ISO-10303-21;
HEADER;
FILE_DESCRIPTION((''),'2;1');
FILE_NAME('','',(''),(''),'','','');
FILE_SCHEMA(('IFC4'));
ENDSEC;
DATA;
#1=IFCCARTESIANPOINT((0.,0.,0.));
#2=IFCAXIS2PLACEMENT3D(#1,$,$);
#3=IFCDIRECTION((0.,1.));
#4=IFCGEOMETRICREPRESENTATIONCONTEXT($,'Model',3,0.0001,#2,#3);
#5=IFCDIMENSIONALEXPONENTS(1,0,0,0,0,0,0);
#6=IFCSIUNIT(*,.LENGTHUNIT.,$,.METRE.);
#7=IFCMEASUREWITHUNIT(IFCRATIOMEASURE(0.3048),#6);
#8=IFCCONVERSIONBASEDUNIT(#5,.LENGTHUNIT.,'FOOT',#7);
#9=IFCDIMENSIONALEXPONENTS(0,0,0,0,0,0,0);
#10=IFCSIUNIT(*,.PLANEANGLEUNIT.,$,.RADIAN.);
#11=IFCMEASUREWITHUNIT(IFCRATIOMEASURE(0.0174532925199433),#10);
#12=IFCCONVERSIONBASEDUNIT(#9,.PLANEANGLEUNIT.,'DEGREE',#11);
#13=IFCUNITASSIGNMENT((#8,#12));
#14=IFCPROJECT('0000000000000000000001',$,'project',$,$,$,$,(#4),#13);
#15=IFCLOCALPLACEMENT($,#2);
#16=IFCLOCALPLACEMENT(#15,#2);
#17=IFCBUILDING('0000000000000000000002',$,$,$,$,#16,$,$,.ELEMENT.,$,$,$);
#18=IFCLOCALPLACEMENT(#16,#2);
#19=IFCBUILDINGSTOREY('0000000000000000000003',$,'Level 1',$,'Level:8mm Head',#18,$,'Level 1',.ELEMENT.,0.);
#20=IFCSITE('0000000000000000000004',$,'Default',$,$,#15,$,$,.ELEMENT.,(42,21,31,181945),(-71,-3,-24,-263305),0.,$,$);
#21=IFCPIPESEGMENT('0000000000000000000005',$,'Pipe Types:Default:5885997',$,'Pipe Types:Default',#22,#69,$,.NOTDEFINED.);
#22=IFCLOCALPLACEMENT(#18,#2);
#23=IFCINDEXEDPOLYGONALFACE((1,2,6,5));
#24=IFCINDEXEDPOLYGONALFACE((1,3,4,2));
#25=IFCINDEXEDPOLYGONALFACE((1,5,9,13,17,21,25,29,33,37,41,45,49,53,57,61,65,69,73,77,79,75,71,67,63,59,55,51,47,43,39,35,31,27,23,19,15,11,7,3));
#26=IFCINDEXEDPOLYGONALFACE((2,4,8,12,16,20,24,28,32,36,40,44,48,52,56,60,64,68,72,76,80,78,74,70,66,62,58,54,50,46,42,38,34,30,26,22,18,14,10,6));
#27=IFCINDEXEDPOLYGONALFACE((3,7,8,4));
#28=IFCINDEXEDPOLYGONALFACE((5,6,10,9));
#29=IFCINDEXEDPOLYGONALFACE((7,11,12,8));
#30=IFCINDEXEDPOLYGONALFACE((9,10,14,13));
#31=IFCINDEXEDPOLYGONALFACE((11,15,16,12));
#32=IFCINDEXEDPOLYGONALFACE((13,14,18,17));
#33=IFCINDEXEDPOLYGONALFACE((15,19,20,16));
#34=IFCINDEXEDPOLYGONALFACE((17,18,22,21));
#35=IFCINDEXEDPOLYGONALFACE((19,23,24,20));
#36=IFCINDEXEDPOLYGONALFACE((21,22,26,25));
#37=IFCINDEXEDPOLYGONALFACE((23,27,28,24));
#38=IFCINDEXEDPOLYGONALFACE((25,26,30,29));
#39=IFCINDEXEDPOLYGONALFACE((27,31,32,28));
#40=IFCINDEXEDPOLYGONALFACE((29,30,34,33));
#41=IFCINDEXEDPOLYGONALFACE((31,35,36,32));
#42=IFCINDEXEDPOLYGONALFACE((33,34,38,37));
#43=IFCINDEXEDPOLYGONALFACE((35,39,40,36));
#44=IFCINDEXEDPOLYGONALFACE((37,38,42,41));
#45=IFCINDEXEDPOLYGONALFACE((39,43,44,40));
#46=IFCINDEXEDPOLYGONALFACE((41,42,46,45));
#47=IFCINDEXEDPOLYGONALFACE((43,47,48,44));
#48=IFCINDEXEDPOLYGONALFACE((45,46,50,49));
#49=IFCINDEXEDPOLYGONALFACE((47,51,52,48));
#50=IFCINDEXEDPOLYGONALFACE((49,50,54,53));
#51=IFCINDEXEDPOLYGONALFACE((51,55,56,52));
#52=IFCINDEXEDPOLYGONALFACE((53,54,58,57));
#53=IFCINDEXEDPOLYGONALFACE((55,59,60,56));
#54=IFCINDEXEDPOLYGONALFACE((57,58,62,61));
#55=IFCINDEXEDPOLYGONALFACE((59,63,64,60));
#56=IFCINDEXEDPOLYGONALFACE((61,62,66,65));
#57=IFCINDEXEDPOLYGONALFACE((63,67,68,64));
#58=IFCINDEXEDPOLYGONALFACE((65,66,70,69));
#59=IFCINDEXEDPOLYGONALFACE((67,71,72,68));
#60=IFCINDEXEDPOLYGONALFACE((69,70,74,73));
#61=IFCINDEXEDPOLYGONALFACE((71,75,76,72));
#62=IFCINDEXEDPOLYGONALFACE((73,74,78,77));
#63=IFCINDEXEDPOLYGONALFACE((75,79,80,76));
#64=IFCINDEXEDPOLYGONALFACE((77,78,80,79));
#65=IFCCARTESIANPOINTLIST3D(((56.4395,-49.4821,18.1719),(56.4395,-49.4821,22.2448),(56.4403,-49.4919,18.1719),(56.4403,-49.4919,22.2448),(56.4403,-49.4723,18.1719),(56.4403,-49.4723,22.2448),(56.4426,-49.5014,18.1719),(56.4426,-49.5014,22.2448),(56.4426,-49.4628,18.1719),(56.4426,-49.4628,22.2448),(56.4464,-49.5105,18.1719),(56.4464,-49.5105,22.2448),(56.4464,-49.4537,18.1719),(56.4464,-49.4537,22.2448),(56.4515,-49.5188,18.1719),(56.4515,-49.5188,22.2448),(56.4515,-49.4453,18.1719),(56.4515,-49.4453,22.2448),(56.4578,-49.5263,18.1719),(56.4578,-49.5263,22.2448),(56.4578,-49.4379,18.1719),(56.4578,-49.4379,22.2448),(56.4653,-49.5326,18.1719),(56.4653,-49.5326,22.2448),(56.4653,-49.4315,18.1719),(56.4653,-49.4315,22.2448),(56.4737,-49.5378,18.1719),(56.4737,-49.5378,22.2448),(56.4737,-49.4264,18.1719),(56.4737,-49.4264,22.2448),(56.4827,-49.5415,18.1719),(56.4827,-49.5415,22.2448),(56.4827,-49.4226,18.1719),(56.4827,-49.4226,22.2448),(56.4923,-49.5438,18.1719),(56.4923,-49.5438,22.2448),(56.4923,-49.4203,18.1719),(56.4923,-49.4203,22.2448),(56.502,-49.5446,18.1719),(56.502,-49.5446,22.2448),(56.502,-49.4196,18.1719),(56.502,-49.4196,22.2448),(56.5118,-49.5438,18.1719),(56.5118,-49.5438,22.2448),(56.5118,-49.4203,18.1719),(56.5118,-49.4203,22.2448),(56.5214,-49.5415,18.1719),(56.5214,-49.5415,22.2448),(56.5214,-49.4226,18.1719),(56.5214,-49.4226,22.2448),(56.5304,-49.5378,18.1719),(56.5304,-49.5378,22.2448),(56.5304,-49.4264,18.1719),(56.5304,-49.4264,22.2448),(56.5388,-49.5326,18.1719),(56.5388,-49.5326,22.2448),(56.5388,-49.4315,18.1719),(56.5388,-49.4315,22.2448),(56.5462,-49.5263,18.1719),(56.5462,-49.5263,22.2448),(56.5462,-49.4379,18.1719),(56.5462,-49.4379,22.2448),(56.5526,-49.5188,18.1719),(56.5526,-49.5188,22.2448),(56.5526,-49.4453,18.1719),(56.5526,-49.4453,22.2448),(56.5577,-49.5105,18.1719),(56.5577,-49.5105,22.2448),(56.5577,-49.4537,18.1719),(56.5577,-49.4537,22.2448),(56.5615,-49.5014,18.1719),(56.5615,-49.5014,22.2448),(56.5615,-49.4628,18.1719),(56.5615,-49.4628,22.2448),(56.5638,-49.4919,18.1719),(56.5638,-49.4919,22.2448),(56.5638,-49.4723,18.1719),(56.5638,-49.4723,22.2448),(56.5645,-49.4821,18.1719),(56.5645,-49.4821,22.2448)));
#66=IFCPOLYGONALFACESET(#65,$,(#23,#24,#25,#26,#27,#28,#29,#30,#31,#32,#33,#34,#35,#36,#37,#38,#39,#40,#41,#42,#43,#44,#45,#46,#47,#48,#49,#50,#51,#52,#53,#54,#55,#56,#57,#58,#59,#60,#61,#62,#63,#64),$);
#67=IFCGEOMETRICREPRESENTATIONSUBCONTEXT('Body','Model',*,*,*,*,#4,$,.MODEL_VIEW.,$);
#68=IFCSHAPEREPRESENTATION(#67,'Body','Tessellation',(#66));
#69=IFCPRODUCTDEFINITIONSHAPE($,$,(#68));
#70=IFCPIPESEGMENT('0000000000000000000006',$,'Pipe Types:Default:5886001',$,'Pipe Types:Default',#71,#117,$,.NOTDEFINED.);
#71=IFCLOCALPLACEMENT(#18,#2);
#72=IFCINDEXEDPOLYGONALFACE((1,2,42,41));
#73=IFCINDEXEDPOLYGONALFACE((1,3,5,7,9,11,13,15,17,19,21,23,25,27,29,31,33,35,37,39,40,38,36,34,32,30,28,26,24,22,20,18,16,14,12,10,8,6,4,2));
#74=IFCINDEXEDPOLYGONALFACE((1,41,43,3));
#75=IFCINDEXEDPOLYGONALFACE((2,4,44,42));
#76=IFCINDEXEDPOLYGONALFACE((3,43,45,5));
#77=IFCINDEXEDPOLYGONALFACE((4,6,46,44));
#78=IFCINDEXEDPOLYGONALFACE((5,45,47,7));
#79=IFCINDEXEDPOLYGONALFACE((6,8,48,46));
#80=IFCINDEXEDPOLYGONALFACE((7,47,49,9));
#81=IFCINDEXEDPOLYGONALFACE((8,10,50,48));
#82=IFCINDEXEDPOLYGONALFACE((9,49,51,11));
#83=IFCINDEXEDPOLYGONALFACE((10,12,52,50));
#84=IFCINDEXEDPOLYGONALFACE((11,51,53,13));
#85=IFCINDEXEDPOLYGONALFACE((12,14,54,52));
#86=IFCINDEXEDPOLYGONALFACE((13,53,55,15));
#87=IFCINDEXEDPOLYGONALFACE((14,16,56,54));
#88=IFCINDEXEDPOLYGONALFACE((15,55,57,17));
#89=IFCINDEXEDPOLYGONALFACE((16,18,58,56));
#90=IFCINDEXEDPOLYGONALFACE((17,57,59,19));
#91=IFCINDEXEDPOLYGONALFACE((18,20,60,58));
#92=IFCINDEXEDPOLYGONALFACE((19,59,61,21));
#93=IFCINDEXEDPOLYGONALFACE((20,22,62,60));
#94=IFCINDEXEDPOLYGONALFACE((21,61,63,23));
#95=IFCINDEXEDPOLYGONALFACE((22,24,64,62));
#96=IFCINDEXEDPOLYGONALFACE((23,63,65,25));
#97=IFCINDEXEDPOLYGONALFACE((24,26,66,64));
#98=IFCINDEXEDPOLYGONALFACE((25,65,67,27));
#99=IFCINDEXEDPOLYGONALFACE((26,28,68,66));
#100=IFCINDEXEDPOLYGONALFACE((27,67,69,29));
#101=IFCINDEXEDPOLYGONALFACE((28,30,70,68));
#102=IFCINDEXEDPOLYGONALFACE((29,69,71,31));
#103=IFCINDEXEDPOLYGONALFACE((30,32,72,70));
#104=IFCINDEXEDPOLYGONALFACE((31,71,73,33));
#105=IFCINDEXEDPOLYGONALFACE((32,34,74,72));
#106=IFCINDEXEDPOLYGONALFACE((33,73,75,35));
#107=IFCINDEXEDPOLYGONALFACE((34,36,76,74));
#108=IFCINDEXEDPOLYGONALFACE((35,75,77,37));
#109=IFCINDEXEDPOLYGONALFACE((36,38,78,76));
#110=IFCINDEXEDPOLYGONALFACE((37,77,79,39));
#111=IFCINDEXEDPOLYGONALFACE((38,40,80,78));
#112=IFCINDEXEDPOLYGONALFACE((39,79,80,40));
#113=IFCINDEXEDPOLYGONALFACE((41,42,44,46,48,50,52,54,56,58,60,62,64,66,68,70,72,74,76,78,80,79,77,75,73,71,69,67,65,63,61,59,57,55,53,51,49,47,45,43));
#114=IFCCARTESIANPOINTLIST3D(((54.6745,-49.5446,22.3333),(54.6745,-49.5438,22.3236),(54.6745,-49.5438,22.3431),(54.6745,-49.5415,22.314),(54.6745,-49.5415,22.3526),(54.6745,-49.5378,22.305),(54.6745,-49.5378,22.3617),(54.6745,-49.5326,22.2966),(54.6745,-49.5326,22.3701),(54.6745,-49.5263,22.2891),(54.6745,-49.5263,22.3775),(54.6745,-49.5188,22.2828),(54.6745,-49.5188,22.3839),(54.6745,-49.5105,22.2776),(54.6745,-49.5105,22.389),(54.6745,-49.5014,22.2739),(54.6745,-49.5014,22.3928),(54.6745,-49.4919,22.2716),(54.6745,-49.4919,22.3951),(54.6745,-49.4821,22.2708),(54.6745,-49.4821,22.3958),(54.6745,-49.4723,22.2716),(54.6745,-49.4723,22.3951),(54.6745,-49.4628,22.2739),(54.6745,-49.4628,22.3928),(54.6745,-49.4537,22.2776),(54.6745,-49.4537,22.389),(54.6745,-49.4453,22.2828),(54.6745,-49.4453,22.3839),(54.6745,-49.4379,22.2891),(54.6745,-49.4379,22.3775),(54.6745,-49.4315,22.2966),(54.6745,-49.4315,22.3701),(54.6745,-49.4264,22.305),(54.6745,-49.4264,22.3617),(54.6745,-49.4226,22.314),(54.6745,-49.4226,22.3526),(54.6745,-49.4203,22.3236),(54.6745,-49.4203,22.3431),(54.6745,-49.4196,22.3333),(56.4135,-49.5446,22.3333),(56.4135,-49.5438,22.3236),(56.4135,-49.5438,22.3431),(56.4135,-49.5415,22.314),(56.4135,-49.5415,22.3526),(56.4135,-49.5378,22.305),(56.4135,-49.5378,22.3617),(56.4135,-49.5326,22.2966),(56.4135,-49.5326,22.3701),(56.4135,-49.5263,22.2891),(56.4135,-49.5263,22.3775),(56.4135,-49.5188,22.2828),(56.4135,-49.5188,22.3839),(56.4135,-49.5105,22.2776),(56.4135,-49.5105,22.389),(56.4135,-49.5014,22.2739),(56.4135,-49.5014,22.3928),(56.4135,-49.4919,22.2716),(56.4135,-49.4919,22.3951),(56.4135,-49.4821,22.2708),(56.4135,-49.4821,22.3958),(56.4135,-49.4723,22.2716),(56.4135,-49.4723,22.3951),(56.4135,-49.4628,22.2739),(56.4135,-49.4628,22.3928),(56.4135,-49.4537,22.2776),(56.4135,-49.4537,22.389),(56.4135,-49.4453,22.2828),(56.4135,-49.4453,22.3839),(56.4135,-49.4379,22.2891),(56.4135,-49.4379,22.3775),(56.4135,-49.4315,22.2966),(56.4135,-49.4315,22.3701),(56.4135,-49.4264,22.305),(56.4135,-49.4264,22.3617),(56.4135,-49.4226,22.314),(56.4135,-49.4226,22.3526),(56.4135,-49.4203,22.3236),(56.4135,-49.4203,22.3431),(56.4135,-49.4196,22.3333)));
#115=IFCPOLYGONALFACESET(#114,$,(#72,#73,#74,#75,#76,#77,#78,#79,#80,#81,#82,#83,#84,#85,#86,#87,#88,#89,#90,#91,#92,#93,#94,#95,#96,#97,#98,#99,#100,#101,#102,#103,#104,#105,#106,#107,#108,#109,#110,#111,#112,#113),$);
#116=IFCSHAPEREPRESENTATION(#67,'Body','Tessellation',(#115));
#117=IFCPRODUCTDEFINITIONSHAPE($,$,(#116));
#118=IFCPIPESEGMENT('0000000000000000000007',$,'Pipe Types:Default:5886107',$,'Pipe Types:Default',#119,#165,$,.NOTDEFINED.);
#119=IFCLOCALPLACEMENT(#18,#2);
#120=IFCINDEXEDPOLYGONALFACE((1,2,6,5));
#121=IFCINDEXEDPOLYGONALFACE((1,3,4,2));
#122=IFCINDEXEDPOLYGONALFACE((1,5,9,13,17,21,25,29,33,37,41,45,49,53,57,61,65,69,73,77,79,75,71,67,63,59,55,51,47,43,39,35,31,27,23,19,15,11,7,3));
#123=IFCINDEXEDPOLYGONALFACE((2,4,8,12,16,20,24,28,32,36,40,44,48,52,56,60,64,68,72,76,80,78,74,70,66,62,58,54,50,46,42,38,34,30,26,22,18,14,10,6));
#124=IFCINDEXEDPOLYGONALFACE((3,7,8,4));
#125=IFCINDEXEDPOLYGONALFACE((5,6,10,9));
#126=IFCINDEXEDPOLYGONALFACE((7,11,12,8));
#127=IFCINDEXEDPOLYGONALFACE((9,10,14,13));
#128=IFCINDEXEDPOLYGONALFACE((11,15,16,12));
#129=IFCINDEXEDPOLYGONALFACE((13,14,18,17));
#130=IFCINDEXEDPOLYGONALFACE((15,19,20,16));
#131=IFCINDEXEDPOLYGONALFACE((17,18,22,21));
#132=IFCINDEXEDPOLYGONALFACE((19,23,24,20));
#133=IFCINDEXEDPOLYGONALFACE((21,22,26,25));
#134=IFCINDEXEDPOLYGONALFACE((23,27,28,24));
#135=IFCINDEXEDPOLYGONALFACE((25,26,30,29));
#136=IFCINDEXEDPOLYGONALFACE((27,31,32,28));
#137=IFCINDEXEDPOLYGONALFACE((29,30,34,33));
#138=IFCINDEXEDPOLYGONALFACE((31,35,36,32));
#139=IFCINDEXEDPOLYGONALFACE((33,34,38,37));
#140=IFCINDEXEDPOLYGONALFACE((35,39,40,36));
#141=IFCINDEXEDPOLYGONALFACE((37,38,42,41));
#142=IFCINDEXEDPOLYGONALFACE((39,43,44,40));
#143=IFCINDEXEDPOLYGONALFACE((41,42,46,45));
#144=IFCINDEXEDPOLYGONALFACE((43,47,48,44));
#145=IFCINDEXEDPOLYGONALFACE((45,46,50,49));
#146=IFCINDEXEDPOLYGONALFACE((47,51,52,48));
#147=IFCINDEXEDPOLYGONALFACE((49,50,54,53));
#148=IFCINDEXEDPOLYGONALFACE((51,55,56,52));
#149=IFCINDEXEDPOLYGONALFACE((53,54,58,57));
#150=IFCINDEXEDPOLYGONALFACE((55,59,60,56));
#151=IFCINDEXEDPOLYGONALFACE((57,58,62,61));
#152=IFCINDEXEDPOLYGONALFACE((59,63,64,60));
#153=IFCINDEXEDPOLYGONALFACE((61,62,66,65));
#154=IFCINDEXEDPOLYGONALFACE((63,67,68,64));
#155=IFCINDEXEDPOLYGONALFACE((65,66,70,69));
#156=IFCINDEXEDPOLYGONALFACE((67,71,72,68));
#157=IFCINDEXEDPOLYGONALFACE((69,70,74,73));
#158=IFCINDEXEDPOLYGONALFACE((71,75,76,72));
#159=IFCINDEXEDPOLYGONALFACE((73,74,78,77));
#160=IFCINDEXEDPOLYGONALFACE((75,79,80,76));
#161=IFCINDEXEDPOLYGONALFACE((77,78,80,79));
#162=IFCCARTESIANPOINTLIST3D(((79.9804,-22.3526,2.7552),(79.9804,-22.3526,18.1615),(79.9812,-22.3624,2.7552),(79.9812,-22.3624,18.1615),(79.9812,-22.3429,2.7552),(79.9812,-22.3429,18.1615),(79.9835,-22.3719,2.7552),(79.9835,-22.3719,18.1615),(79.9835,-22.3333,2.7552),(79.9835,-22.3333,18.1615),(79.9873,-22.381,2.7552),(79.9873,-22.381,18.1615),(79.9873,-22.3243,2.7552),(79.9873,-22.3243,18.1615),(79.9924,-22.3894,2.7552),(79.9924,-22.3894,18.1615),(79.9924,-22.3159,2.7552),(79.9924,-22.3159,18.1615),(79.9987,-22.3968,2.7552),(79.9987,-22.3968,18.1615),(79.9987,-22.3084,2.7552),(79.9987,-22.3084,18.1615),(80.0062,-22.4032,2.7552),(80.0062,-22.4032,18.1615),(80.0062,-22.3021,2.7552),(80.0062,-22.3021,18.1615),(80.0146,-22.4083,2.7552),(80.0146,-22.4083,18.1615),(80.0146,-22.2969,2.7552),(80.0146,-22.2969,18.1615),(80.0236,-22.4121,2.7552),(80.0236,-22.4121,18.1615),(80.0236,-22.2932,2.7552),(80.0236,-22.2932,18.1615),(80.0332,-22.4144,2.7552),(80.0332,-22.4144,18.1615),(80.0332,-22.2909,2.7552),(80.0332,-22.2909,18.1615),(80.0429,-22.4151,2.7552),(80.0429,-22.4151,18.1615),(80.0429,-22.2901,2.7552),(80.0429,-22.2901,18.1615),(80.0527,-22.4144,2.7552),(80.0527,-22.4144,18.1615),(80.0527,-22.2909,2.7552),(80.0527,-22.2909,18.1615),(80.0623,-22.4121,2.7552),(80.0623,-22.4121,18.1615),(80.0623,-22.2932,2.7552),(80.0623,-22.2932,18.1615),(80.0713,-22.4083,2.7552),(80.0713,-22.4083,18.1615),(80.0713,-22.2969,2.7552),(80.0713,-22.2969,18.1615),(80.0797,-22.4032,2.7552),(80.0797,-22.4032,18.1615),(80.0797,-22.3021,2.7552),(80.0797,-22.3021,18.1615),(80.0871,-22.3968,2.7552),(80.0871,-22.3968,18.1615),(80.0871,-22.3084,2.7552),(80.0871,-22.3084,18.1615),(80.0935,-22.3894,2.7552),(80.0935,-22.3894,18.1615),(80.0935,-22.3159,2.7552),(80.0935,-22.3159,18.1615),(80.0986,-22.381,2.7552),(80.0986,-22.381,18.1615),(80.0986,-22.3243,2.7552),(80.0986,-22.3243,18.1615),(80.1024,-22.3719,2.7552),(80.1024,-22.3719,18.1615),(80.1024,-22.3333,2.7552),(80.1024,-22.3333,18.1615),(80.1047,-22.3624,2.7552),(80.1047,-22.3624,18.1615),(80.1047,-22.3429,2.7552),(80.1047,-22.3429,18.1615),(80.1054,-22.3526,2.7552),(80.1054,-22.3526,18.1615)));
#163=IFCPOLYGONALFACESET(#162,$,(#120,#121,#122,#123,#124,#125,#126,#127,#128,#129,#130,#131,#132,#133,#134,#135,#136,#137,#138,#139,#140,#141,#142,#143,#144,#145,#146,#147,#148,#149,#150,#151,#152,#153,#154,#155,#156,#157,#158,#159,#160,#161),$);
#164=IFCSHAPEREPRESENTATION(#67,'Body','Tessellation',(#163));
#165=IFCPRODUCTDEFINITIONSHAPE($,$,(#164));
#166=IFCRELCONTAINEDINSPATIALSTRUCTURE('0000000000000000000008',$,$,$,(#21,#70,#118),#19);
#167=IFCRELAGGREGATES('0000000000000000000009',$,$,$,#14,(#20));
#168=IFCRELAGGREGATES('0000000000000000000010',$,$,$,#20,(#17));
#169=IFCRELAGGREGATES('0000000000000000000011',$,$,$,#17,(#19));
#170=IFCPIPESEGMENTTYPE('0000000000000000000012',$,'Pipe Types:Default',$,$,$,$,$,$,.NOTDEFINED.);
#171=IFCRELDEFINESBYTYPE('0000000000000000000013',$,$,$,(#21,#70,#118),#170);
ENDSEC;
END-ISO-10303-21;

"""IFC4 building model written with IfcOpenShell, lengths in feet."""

from ifc_helpers import new_model, entity, si_unit, converted_unit, direction, frame, origin, place, context, subcontext, project, spatial, indexed_curve, outline, extrude, type_object, element, save


model = new_model("IFC4")

# Units and contexts
model_context = context("Model", 3, precision=0.0001, world=origin(), true_north=direction((0.0, 1.0)))
body_context = subcontext(model_context, "Body", "Model", "MODEL_VIEW")
ifc_project = project(units=[converted_unit("LENGTHUNIT", "FOOT", entity("IfcRatioMeasure", 0.3048), si_unit("LENGTHUNIT", "METRE"), dimensions=[1, 0, 0, 0, 0, 0, 0]), converted_unit("PLANEANGLEUNIT", "DEGREE", entity("IfcRatioMeasure", 0.0174532925199433), si_unit("PLANEANGLEUNIT", "RADIAN"), dimensions=[0, 0, 0, 0, 0, 0, 0])], contexts=[model_context])

# Site, building, storey
site_placement = place(None, origin())
site = spatial("IfcSite", under=ifc_project, at=site_placement, Name="Default", CompositionType="ELEMENT", RefLatitude=(42, 21, 31, 181945), RefLongitude=(-71, -3, -24, -263305), RefElevation=0.0)
building_placement = place(site_placement, origin())
building = spatial("IfcBuilding", under=site, at=building_placement, CompositionType="ELEMENT")
storey_placement = place(building_placement, origin())
storey = spatial("IfcBuildingStorey", under=building, at=storey_placement, Name="Level 1", ObjectType="Level:8mm Head", LongName="Level 1", CompositionType="ELEMENT", Elevation=0.0)

# Pipe segments
pipe_segment_type = type_object("IfcPipeSegmentType", Name="Pipe Types:Default", PredefinedType="NOTDEFINED")
pipe_segment_1_placement = place(storey_placement, origin())
element("IfcPipeSegment", 1, at=pipe_segment_1_placement, inside=storey, type_object=pipe_segment_type, Name="Pipe Types:Default:5885997", ObjectType="Pipe Types:Default", PredefinedType="NOTDEFINED", context=body_context, shape_type="SweptSolid", body=[
    extrude(outline(indexed_curve([(0.0625, 0.0), (0.0617, 0.0098), (0.0594, 0.0193), (0.0557, 0.0284), (0.0506, 0.0367), (0.0442, 0.0442), (0.0367, 0.0506), (0.0284, 0.0557), (0.0193, 0.0594), (0.0098, 0.0617), (0.0, 0.0625), (-0.0098, 0.0617), (-0.0193, 0.0594), (-0.0284, 0.0557), (-0.0367, 0.0506), (-0.0442, 0.0442), (-0.0506, 0.0367), (-0.0557, 0.0284), (-0.0594, 0.0193), (-0.0617, 0.0098), (-0.0625, 0.0), (-0.0617, -0.0098), (-0.0594, -0.0193), (-0.0557, -0.0284), (-0.0506, -0.0367), (-0.0442, -0.0442), (-0.0367, -0.0506), (-0.0284, -0.0557), (-0.0193, -0.0594), (-0.0098, -0.0617), (0.0, -0.0625), (0.0098, -0.0617), (0.0193, -0.0594), (0.0284, -0.0557), (0.0367, -0.0506), (0.0442, -0.0442), (0.0506, -0.0367), (0.0557, -0.0284), (0.0594, -0.0193), (0.0617, -0.0098), (0.0625, 0.0)], self_intersect=False)), frame((56.502, -49.4821, 18.1719), z_axis=(0.0, 0.0, 1.0), x_axis=(-1.0, 0.0, 0.0)), (0.0, 0.0, 1.0), 4.0729),
])
pipe_segment_2_placement = place(storey_placement, origin())
element("IfcPipeSegment", 2, at=pipe_segment_2_placement, inside=storey, type_object=pipe_segment_type, Name="Pipe Types:Default:5886001", ObjectType="Pipe Types:Default", PredefinedType="NOTDEFINED", context=body_context, shape_type="SweptSolid", body=[
    extrude(outline(indexed_curve([(0.0625, 0.0), (0.0617, 0.0098), (0.0594, 0.0193), (0.0557, 0.0284), (0.0506, 0.0367), (0.0442, 0.0442), (0.0367, 0.0506), (0.0284, 0.0557), (0.0193, 0.0594), (0.0098, 0.0617), (0.0, 0.0625), (-0.0098, 0.0617), (-0.0193, 0.0594), (-0.0284, 0.0557), (-0.0367, 0.0506), (-0.0442, 0.0442), (-0.0506, 0.0367), (-0.0557, 0.0284), (-0.0594, 0.0193), (-0.0617, 0.0098), (-0.0625, 0.0), (-0.0617, -0.0098), (-0.0594, -0.0193), (-0.0557, -0.0284), (-0.0506, -0.0367), (-0.0442, -0.0442), (-0.0367, -0.0506), (-0.0284, -0.0557), (-0.0193, -0.0594), (-0.0098, -0.0617), (0.0, -0.0625), (0.0098, -0.0617), (0.0193, -0.0594), (0.0284, -0.0557), (0.0367, -0.0506), (0.0442, -0.0442), (0.0506, -0.0367), (0.0557, -0.0284), (0.0594, -0.0193), (0.0617, -0.0098), (0.0625, 0.0)], self_intersect=False)), frame((54.6745, -49.4821, 22.3333), z_axis=(1.0, 0.0, 0.0), x_axis=(0.0, 1.0, 0.0)), (0.0, 0.0, 1.0), 1.739),
])
pipe_segment_3_placement = place(storey_placement, origin())
element("IfcPipeSegment", 3, at=pipe_segment_3_placement, inside=storey, type_object=pipe_segment_type, Name="Pipe Types:Default:5886107", ObjectType="Pipe Types:Default", PredefinedType="NOTDEFINED", context=body_context, shape_type="SweptSolid", body=[
    extrude(outline(indexed_curve([(0.0625, 0.0), (0.0617, 0.0098), (0.0594, 0.0193), (0.0557, 0.0284), (0.0506, 0.0367), (0.0442, 0.0442), (0.0367, 0.0506), (0.0284, 0.0557), (0.0193, 0.0594), (0.0098, 0.0617), (0.0, 0.0625), (-0.0098, 0.0617), (-0.0193, 0.0594), (-0.0284, 0.0557), (-0.0367, 0.0506), (-0.0442, 0.0442), (-0.0506, 0.0367), (-0.0557, 0.0284), (-0.0594, 0.0193), (-0.0617, 0.0098), (-0.0625, 0.0), (-0.0617, -0.0098), (-0.0594, -0.0193), (-0.0557, -0.0284), (-0.0506, -0.0367), (-0.0442, -0.0442), (-0.0367, -0.0506), (-0.0284, -0.0557), (-0.0193, -0.0594), (-0.0098, -0.0617), (0.0, -0.0625), (0.0098, -0.0617), (0.0193, -0.0594), (0.0284, -0.0557), (0.0367, -0.0506), (0.0442, -0.0442), (0.0506, -0.0367), (0.0557, -0.0284), (0.0594, -0.0193), (0.0617, -0.0098), (0.0625, 0.0)], self_intersect=False)), frame((80.0429, -22.3526, 2.7552), z_axis=(0.0, 0.0, 1.0), x_axis=(-1.0, 0.0, 0.0)), (0.0, 0.0, 1.0), 15.4063),
])

save(model, "model.ifc")
